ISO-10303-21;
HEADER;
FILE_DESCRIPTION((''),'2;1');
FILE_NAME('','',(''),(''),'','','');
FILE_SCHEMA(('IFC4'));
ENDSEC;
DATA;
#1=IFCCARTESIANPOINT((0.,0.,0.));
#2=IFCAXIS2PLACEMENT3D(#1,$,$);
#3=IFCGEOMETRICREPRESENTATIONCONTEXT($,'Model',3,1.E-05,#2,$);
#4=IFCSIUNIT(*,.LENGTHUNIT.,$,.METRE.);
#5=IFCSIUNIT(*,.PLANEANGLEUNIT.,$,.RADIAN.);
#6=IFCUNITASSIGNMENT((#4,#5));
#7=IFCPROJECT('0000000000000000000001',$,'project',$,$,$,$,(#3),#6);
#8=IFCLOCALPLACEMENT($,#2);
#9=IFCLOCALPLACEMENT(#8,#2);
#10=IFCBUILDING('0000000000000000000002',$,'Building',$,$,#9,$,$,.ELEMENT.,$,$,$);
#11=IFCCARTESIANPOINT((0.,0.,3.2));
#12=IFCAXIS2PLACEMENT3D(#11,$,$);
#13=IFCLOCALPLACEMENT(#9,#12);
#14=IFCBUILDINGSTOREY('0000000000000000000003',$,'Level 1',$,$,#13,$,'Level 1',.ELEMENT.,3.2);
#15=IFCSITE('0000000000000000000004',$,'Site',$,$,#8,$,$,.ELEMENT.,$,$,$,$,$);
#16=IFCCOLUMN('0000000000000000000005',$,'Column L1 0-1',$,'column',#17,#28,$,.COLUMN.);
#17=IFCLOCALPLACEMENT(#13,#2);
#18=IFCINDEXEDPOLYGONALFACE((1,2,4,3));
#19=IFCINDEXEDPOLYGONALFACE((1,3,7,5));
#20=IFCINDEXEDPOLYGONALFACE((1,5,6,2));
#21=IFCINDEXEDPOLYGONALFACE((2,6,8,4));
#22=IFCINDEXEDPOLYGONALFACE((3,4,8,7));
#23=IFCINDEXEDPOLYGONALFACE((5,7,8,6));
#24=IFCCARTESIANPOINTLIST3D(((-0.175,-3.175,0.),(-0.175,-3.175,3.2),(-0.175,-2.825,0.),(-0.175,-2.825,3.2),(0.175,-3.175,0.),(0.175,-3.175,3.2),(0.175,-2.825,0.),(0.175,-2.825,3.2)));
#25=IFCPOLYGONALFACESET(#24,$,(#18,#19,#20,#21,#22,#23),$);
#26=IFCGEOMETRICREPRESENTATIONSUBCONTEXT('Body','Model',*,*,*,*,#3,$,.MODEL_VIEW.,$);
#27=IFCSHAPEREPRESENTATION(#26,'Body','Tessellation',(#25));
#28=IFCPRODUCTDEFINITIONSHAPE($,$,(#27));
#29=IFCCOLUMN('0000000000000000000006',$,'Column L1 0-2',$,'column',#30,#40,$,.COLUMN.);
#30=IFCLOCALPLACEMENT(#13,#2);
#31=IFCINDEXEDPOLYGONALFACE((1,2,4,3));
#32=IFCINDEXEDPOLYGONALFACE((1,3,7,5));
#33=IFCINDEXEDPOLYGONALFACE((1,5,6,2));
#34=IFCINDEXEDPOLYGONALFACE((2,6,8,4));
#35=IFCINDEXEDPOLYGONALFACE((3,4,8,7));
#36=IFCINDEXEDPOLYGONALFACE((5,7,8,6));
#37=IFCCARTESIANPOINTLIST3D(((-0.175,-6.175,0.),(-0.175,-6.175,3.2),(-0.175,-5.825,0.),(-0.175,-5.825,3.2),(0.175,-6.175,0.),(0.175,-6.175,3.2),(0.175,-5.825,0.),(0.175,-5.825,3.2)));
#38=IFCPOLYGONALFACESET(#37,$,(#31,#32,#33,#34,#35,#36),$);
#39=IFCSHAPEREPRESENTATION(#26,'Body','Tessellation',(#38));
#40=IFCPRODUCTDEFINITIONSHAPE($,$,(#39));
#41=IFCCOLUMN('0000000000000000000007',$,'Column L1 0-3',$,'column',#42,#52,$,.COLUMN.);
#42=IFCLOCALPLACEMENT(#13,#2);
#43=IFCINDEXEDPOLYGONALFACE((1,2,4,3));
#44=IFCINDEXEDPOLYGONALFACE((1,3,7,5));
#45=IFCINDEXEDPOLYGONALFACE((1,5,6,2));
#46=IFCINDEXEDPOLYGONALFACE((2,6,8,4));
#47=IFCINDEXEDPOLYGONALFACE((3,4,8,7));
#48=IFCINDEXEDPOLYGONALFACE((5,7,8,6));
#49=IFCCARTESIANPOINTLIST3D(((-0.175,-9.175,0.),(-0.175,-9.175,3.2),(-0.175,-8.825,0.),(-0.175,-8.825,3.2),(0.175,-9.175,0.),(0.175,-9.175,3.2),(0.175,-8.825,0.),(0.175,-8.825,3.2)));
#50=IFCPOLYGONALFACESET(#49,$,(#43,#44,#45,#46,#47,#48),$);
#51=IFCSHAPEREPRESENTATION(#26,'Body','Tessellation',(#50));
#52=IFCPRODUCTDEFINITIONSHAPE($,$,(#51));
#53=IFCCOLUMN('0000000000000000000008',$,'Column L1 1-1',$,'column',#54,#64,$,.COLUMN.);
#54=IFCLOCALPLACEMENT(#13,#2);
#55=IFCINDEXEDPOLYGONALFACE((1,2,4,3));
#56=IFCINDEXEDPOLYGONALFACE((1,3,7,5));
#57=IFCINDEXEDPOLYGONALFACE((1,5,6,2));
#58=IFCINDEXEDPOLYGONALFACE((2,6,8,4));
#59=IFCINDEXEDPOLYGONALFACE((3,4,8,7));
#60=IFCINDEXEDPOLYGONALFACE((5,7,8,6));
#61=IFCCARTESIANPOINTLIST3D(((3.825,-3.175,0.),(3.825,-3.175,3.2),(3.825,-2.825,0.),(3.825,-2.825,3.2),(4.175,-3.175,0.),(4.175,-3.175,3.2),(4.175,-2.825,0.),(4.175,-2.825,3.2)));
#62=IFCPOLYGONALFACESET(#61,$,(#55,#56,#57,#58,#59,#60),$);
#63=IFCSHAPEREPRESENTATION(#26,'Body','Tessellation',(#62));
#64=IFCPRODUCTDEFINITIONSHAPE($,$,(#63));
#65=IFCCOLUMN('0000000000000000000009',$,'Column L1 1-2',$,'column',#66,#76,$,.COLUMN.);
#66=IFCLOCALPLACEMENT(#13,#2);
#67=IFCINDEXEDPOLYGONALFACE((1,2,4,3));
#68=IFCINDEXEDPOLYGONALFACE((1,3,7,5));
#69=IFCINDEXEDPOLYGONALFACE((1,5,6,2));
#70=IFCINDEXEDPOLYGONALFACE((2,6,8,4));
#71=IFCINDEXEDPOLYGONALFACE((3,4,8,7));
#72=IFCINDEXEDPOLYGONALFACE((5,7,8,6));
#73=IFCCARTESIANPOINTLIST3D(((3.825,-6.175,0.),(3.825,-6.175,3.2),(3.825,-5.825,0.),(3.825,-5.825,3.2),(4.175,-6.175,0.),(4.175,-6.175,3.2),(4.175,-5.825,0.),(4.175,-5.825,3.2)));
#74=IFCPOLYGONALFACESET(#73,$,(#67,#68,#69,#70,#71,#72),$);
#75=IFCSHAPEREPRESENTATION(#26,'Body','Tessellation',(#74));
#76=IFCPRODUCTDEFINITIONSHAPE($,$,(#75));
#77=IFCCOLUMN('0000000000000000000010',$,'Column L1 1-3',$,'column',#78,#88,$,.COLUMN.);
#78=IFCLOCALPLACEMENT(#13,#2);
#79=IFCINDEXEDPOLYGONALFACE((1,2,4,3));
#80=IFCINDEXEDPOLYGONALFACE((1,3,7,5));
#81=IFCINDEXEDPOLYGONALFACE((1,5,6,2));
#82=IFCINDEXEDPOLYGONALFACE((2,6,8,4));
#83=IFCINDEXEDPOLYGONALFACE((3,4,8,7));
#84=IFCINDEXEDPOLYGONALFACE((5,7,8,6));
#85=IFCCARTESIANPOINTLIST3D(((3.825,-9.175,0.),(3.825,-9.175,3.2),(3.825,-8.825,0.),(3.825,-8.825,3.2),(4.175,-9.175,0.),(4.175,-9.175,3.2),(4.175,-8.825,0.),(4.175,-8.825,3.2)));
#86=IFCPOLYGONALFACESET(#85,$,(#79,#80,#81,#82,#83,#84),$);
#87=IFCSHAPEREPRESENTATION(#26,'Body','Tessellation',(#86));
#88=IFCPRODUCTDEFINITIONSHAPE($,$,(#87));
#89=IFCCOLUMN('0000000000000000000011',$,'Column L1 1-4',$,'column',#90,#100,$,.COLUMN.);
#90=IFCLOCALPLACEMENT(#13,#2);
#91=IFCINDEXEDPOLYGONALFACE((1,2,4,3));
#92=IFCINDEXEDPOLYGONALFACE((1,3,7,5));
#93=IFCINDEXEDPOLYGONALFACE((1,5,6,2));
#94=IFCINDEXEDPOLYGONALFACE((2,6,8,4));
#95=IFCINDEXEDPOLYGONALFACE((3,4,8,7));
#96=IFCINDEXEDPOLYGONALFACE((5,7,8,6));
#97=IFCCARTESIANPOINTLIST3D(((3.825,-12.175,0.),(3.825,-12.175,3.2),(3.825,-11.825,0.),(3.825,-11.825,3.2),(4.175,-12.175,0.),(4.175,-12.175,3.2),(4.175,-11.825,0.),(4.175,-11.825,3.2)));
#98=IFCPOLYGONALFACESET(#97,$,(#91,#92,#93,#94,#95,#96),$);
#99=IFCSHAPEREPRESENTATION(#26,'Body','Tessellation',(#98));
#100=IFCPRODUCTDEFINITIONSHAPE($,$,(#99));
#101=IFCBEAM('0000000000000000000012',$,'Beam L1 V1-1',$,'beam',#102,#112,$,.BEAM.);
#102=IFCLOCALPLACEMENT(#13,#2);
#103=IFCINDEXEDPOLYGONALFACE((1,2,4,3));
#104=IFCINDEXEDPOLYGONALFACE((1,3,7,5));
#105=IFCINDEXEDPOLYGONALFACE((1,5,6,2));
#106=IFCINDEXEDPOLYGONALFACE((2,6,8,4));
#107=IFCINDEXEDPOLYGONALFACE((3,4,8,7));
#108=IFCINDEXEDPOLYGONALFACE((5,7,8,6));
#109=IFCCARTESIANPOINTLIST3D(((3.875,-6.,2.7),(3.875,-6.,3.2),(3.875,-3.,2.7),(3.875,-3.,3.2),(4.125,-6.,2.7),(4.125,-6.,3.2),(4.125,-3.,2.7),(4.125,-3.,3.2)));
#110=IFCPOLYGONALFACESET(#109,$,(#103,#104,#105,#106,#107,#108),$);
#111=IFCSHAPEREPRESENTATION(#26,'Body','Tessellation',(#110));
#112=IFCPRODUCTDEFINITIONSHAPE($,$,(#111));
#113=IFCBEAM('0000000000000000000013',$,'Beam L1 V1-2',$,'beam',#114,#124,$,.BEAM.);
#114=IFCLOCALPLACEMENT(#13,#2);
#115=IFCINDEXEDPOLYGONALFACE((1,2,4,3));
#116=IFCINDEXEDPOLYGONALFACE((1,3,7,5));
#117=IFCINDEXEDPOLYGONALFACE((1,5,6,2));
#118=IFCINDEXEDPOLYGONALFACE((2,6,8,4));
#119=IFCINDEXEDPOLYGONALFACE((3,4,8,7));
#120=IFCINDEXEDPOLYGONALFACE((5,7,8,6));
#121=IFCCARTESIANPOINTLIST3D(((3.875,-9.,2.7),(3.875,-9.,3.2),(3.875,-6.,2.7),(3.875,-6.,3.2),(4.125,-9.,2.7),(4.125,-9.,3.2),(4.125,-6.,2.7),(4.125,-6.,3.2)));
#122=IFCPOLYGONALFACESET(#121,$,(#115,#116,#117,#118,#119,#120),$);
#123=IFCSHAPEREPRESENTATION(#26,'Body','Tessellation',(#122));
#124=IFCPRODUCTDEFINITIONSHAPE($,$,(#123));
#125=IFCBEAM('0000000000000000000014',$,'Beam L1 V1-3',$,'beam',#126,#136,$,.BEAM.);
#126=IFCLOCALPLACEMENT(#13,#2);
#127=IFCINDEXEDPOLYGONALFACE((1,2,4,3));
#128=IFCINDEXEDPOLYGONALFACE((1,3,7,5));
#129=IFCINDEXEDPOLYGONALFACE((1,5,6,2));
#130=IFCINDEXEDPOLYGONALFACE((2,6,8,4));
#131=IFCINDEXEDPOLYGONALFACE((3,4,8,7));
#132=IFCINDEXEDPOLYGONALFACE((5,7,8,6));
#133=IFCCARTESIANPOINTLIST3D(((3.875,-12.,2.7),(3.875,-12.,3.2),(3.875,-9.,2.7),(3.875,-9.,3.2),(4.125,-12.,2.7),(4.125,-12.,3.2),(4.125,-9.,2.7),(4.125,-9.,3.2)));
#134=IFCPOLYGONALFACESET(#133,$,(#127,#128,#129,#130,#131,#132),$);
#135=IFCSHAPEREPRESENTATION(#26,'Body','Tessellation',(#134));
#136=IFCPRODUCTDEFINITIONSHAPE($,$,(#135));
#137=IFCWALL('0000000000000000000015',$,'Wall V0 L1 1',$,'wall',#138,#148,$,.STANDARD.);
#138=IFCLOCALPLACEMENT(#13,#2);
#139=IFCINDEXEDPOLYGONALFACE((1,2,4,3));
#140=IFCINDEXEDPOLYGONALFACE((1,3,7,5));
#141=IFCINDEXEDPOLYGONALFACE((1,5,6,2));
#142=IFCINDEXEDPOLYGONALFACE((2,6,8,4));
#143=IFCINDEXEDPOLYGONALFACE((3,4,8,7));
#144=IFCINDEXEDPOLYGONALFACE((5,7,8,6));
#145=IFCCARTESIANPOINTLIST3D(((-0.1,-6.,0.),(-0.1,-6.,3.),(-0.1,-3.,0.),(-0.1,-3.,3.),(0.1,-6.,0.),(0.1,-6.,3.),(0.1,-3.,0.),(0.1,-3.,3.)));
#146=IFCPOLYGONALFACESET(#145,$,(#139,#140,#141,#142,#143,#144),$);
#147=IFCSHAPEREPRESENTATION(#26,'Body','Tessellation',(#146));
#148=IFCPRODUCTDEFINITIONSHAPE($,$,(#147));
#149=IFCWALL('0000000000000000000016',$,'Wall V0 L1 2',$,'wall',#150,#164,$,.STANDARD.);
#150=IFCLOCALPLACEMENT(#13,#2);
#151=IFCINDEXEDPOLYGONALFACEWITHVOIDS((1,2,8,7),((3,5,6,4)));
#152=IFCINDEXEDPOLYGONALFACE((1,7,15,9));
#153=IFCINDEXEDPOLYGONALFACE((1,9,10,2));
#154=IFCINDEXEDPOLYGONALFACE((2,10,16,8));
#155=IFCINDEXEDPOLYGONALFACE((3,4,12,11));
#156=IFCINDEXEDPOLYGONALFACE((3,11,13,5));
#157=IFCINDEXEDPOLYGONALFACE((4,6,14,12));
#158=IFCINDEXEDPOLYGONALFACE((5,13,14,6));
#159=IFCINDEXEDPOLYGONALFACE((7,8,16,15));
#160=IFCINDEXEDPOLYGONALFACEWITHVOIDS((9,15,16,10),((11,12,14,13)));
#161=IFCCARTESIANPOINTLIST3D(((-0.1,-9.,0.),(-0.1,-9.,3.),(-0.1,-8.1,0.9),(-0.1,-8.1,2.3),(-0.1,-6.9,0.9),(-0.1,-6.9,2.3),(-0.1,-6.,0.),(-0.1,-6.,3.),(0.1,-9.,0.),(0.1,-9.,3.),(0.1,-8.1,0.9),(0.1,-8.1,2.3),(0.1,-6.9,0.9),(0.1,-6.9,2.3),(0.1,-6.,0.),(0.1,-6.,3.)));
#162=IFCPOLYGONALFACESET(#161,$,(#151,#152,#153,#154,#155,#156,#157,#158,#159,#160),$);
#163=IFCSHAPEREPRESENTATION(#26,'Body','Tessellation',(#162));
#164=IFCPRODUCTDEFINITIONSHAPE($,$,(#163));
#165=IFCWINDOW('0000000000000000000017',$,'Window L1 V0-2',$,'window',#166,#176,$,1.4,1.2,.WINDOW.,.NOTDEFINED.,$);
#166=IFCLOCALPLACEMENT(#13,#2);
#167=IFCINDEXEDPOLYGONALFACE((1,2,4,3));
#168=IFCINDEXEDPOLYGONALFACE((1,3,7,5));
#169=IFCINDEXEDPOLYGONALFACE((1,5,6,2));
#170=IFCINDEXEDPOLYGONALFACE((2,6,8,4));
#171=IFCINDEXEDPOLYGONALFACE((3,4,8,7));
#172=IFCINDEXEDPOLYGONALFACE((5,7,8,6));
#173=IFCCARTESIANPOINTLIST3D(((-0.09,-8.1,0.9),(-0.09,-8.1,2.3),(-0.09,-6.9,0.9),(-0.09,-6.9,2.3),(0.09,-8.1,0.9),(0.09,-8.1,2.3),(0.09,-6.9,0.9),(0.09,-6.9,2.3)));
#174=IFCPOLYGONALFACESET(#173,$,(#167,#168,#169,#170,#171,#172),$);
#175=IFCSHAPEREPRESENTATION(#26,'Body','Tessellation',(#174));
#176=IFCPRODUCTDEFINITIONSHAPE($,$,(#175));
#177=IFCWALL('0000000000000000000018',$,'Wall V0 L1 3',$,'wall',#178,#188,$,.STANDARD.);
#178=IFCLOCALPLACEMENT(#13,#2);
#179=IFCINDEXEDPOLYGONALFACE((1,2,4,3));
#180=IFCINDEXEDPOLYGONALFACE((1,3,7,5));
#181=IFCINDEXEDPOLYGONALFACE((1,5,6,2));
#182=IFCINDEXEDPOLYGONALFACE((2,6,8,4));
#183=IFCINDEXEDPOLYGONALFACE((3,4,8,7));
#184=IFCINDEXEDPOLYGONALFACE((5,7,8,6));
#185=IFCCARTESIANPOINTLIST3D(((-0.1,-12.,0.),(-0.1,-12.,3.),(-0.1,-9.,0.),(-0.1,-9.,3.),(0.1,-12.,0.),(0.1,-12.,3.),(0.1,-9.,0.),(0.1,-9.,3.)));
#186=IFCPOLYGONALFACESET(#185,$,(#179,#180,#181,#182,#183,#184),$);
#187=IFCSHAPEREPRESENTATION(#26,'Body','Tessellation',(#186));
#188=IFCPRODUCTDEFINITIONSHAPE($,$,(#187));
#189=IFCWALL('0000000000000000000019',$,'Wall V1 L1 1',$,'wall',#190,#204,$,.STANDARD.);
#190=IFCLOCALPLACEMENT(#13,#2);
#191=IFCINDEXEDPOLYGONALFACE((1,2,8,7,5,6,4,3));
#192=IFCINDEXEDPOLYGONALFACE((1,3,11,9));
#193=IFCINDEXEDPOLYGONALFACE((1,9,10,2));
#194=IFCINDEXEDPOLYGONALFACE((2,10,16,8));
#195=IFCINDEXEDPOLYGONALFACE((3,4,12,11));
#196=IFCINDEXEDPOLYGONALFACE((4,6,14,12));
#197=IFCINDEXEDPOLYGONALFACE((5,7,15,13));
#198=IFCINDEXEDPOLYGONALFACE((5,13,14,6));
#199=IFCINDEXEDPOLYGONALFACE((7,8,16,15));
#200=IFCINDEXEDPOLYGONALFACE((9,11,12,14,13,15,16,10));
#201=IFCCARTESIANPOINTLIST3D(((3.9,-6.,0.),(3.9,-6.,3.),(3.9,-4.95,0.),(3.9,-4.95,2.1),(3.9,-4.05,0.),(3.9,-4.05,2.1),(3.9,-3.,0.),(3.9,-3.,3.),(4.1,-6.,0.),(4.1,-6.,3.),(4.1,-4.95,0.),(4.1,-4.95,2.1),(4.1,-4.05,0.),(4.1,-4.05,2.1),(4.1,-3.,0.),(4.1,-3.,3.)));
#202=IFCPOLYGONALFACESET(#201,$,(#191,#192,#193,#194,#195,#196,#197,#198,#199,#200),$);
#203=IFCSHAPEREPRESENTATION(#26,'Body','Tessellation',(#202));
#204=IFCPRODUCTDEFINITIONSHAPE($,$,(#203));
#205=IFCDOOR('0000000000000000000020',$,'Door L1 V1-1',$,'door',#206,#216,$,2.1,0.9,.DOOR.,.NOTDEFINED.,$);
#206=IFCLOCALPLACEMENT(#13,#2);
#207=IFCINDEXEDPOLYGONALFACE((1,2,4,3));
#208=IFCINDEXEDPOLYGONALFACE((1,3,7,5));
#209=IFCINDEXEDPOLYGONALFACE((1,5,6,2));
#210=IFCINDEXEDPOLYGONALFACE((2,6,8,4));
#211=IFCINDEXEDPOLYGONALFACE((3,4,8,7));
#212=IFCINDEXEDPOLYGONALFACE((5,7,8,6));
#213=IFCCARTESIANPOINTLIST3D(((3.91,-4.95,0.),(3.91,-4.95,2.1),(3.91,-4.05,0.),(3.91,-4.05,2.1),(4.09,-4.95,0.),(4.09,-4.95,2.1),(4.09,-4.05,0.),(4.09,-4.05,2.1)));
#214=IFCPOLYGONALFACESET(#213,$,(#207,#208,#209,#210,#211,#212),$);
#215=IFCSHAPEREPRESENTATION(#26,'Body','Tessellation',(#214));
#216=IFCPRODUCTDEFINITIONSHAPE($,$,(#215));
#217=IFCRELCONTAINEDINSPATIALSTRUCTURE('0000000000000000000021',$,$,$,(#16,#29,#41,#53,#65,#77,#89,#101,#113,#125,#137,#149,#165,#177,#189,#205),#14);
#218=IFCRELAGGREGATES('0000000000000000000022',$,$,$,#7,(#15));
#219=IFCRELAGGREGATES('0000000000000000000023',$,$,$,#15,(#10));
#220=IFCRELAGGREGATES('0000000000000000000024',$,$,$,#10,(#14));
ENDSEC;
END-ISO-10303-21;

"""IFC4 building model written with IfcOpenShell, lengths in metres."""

from ifc_helpers import new_model, si_unit, frame, frame_2d, origin, origin_2d, place, context, subcontext, project, spatial, rectangle, extrude, element, fill, save


model = new_model("IFC4")

# Units and contexts
model_context = context("Model", 3, precision=1e-05, world=origin())
body_context = subcontext(model_context, "Body", "Model", "MODEL_VIEW")
ifc_project = project(units=[si_unit("LENGTHUNIT", "METRE"), si_unit("PLANEANGLEUNIT", "RADIAN")], contexts=[model_context])

# Site, building, storey
site_placement = place(None, origin())
site = spatial("IfcSite", under=ifc_project, at=site_placement, Name="Site", CompositionType="ELEMENT")
building_placement = place(site_placement, origin())
building = spatial("IfcBuilding", under=site, at=building_placement, Name="Building", CompositionType="ELEMENT")
storey_placement = place(building_placement, frame((0.0, 0.0, 3.2)))
storey = spatial("IfcBuildingStorey", under=building, at=storey_placement, Name="Level 1", LongName="Level 1", CompositionType="ELEMENT", Elevation=3.2)

# Columns
for number, where, name in (
    (1, (0.0, -3.0, 0.0), "Column L1 0-1"),
    (2, (0.0, -6.0, 0.0), "Column L1 0-2"),
    (3, (0.0, -9.0, 0.0), "Column L1 0-3"),
    (4, (4.0, -3.0, 0.0), "Column L1 1-1"),
    (5, (4.0, -6.0, 0.0), "Column L1 1-2"),
    (6, (4.0, -9.0, 0.0), "Column L1 1-3"),
    (7, (4.0, -12.0, 0.0), "Column L1 1-4"),
):
    element("IfcColumn", number, at=place(storey_placement, frame(where)), inside=storey, Name=name, ObjectType="column", PredefinedType="COLUMN", context=body_context, shape_type="SweptSolid", body=[
        extrude(rectangle(XDim=0.35, YDim=0.35, at=origin_2d()), origin(), (0.0, 0.0, 1.0), 3.2),
    ])

# Beams
for number, where, z_axis, x_axis, name in (
    (8, (4.0, -3.0, 2.95), (0.0, -1.0, 0.0), (0.0, 0.0, 1.0), "Beam L1 V1-1"),
    (9, (4.0, -6.0, 2.95), (0.0, -1.0, 0.0), (0.0, 0.0, 1.0), "Beam L1 V1-2"),
    (10, (4.0, -9.0, 2.95), (0.0, -1.0, 0.0), (0.0, 0.0, 1.0), "Beam L1 V1-3"),
):
    element("IfcBeam", number, at=place(storey_placement, frame(where, z_axis=z_axis, x_axis=x_axis)), inside=storey, Name=name, ObjectType="beam", PredefinedType="BEAM", context=body_context, shape_type="SweptSolid", body=[
        extrude(rectangle(XDim=0.5, YDim=0.25, at=origin_2d()), origin(), (0.0, 0.0, 1.0), 3.0),
    ])

# Wall
wall_1_placement = place(storey_placement, frame((0.0, -3.0, 0.0), z_axis=(0.0, 0.0, 1.0), x_axis=(0.0, -1.0, 0.0)))
element("IfcWall", 11, at=wall_1_placement, inside=storey, Name="Wall V0 L1 1", ObjectType="wall", PredefinedType="STANDARD", context=body_context, shape_type="SweptSolid", body=[
    extrude(rectangle(XDim=3.0, YDim=0.2, at=frame_2d((1.5, 0.0))), origin(), (0.0, 0.0, 1.0), 3.0),
])

# Wall, opening, window
wall_2_placement = place(storey_placement, frame((0.0, -6.0, 0.0), z_axis=(0.0, 0.0, 1.0), x_axis=(0.0, -1.0, 0.0)))
wall_2 = element("IfcWall", 12, at=wall_2_placement, inside=storey, Name="Wall V0 L1 2", ObjectType="wall", PredefinedType="STANDARD", context=body_context, shape_type="SweptSolid", body=[
    extrude(rectangle(XDim=3.0, YDim=0.2, at=frame_2d((1.5, 0.0))), origin(), (0.0, 0.0, 1.0), 3.0),
])
opening_1_placement = place(storey_placement, frame((0.0, -7.5, 0.9), z_axis=(0.0, 0.0, 1.0), x_axis=(0.0, -1.0, 0.0)))
opening_1 = element("IfcOpeningElement", 13, at=opening_1_placement, cuts=wall_2, ObjectType="Opening", PredefinedType="OPENING", context=body_context, shape_type="SweptSolid", body=[
    extrude(rectangle(XDim=1.2, YDim=0.22, at=origin_2d()), origin(), (0.0, 0.0, 1.0), 1.4),
])
window_1_placement = place(storey_placement, frame((0.0, -7.5, 0.9), z_axis=(0.0, 0.0, 1.0), x_axis=(0.0, -1.0, 0.0)))
window_1 = element("IfcWindow", 14, at=window_1_placement, inside=storey, Name="Window L1 V0-2", ObjectType="window", OverallHeight=1.4, OverallWidth=1.2, PartitioningType="NOTDEFINED", PredefinedType="WINDOW", context=body_context, shape_type="SweptSolid", body=[
    extrude(rectangle(XDim=1.2, YDim=0.18, at=origin_2d()), origin(), (0.0, 0.0, 1.0), 1.4),
])
fill(opening_1, window_1)

# Wall
wall_3_placement = place(storey_placement, frame((0.0, -9.0, 0.0), z_axis=(0.0, 0.0, 1.0), x_axis=(0.0, -1.0, 0.0)))
element("IfcWall", 15, at=wall_3_placement, inside=storey, Name="Wall V0 L1 3", ObjectType="wall", PredefinedType="STANDARD", context=body_context, shape_type="SweptSolid", body=[
    extrude(rectangle(XDim=3.0, YDim=0.2, at=frame_2d((1.5, 0.0))), origin(), (0.0, 0.0, 1.0), 3.0),
])

# Wall, opening, door
wall_4_placement = place(storey_placement, frame((4.0, -3.0, 0.0), z_axis=(0.0, 0.0, 1.0), x_axis=(0.0, -1.0, 0.0)))
wall_4 = element("IfcWall", 16, at=wall_4_placement, inside=storey, Name="Wall V1 L1 1", ObjectType="wall", PredefinedType="STANDARD", context=body_context, shape_type="SweptSolid", body=[
    extrude(rectangle(XDim=3.0, YDim=0.2, at=frame_2d((1.5, 0.0))), origin(), (0.0, 0.0, 1.0), 3.0),
])
opening_2_placement = place(storey_placement, frame((4.0, -4.5, 0.0), z_axis=(0.0, 0.0, 1.0), x_axis=(0.0, -1.0, 0.0)))
opening_2 = element("IfcOpeningElement", 17, at=opening_2_placement, cuts=wall_4, ObjectType="Opening", PredefinedType="OPENING", context=body_context, shape_type="SweptSolid", body=[
    extrude(rectangle(XDim=0.9, YDim=0.22, at=origin_2d()), origin(), (0.0, 0.0, 1.0), 2.1),
])
door_1_placement = place(storey_placement, frame((4.0, -4.5, 0.0), z_axis=(0.0, 0.0, 1.0), x_axis=(0.0, -1.0, 0.0)))
door_1 = element("IfcDoor", 18, at=door_1_placement, inside=storey, Name="Door L1 V1-1", ObjectType="door", OperationType="NOTDEFINED", OverallHeight=2.1, OverallWidth=0.9, PredefinedType="DOOR", context=body_context, shape_type="SweptSolid", body=[
    extrude(rectangle(XDim=0.9, YDim=0.18, at=origin_2d()), origin(), (0.0, 0.0, 1.0), 2.1),
])
fill(opening_2, door_1)

save(model, "model.ifc")
